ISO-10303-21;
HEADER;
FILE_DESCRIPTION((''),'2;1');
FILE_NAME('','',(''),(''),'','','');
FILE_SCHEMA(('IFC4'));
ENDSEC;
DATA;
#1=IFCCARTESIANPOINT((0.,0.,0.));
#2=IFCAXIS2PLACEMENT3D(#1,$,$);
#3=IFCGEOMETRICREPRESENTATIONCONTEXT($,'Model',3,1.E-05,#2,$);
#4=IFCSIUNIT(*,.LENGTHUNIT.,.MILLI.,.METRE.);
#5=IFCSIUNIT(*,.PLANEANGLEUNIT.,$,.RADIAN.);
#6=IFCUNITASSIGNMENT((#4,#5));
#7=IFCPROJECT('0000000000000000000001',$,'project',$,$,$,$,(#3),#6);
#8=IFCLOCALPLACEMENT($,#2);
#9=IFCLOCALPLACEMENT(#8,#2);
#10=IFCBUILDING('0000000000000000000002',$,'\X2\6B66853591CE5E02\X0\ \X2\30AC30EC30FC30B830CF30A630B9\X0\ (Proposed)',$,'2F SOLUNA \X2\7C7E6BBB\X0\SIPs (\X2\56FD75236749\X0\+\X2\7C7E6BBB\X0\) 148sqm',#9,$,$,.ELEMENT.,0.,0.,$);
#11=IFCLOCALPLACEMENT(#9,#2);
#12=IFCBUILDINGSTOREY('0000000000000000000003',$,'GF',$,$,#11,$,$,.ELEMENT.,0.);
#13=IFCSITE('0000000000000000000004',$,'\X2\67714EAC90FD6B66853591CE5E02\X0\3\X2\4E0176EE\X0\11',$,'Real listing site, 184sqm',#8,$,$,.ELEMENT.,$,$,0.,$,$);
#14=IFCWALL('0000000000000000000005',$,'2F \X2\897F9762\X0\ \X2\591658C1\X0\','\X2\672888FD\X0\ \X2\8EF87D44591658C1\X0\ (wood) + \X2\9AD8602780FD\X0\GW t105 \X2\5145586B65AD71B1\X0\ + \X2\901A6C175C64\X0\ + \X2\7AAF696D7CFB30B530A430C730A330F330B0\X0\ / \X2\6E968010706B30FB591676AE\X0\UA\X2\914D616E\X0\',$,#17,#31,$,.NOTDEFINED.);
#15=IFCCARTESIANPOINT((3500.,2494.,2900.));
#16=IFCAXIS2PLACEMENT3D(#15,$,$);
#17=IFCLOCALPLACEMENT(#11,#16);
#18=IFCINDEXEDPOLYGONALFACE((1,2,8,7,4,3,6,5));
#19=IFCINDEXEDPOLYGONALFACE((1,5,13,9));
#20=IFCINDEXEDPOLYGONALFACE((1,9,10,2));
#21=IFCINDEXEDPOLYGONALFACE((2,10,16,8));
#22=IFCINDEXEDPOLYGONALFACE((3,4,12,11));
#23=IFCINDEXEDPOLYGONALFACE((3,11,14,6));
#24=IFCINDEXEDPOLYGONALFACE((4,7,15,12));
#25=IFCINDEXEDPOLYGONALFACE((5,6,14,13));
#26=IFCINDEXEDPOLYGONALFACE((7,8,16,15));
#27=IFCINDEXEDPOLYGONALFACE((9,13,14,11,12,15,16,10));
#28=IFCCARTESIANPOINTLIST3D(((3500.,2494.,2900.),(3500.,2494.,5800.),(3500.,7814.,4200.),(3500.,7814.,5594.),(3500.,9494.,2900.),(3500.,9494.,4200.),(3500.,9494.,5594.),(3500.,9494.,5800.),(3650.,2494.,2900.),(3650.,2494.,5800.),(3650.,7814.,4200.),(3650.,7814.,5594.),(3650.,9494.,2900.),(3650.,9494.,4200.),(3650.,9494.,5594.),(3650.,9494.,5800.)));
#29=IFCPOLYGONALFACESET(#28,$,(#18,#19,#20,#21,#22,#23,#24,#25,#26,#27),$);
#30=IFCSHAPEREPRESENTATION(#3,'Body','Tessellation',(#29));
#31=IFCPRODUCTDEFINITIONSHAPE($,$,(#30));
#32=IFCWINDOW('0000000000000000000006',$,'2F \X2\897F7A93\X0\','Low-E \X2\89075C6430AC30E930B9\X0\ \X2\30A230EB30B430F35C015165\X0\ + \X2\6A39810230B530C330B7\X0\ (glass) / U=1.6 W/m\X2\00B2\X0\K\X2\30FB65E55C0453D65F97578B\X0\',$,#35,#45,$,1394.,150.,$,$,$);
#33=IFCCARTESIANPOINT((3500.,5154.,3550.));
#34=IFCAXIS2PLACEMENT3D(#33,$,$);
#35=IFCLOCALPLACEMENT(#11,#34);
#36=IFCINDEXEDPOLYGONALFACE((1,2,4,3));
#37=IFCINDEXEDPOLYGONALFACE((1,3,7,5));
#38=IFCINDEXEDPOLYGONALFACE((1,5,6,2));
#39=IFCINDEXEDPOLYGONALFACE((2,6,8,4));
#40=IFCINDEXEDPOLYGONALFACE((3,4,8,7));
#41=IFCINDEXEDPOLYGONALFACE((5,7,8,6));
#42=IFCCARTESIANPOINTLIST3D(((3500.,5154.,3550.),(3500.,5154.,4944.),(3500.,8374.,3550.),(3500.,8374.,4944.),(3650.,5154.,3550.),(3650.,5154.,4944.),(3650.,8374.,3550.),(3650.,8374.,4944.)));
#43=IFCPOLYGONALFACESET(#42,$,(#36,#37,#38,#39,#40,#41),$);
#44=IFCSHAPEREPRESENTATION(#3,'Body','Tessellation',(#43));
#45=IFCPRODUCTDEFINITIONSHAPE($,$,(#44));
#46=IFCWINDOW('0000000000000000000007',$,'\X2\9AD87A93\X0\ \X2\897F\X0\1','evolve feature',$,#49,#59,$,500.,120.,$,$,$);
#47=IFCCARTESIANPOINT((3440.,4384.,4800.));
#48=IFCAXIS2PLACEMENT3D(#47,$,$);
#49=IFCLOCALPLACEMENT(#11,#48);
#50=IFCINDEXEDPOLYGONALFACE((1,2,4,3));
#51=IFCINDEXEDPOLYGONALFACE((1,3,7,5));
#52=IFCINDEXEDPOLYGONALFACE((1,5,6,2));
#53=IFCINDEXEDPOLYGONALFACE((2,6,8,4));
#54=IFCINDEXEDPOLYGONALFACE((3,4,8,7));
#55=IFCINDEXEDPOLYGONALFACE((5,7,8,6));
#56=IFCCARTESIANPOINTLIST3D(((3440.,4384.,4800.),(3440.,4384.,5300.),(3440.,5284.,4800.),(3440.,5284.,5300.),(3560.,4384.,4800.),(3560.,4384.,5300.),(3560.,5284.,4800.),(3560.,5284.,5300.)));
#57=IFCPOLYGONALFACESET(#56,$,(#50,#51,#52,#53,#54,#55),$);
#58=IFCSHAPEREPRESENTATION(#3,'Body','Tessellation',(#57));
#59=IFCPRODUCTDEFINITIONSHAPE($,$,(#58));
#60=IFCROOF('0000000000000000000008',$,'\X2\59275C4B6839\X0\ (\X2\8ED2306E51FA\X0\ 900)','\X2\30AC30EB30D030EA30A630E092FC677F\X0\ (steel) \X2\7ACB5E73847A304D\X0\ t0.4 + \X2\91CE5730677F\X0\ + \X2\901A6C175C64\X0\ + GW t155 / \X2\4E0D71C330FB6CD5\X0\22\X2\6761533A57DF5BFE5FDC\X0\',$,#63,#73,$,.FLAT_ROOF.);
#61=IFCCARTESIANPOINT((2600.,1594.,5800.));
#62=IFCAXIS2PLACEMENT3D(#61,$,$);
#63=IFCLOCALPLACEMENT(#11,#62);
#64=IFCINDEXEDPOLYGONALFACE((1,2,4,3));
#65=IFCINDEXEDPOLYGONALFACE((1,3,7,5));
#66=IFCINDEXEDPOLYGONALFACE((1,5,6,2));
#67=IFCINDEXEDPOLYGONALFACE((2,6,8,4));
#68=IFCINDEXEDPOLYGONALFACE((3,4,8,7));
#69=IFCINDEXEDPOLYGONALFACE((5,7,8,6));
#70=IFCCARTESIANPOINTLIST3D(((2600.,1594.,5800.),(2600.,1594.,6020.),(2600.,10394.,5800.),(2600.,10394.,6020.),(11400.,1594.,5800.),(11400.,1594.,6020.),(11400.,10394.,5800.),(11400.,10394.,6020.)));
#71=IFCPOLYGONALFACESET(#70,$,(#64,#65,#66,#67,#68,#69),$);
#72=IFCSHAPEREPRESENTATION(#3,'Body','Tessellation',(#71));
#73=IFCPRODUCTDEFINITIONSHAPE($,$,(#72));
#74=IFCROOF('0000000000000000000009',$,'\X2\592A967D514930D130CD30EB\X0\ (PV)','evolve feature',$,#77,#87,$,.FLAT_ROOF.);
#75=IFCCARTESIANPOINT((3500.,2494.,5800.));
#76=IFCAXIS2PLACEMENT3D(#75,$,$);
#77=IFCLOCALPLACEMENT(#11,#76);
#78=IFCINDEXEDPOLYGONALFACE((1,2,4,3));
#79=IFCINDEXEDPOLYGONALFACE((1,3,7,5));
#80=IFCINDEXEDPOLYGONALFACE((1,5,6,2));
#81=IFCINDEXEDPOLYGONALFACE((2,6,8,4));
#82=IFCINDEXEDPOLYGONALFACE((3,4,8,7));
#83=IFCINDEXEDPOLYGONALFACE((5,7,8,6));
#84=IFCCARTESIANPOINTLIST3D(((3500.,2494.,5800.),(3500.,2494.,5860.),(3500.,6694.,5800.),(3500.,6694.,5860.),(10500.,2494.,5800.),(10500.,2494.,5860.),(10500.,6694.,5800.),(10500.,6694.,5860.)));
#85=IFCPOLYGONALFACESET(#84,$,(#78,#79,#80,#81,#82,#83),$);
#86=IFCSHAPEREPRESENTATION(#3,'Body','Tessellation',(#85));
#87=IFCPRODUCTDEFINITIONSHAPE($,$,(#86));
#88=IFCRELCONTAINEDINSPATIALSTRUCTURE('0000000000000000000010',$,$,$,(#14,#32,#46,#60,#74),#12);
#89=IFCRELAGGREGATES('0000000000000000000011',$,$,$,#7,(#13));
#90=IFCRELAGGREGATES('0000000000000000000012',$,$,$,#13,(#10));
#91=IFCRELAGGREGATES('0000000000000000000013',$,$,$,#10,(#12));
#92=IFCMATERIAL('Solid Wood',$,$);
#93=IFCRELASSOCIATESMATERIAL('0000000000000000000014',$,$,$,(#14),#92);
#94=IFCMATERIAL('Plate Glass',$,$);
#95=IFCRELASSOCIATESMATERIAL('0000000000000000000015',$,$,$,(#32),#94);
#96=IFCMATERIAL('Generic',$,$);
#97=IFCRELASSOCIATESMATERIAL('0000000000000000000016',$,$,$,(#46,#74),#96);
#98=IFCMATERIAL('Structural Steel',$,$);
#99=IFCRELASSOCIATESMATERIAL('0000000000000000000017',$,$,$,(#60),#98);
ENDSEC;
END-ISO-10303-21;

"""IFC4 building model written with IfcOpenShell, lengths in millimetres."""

from ifc_helpers import new_model, si_unit, frame, frame_2d, origin, place, context, project, spatial, rectangle, extrude, material, element, fill, save


model = new_model("IFC4")

# Units and contexts
model_context = context("Model", 3, precision=1e-05, world=origin())
ifc_project = project(units=[si_unit("LENGTHUNIT", "METRE", prefix="MILLI"), si_unit("PLANEANGLEUNIT", "RADIAN")], contexts=[model_context])

# Site, building, storey
site_placement = place(None, origin())
site = spatial("IfcSite", under=ifc_project, at=site_placement, Name="東京都武蔵野市3丁目11", ObjectType="Real listing site, 184sqm", CompositionType="ELEMENT", RefElevation=0.0)
building_placement = place(site_placement, origin())
building = spatial("IfcBuilding", under=site, at=building_placement, Name="武蔵野市 ガレージハウス (Proposed)", ObjectType="2F SOLUNA 籾殻SIPs (国産杉+籾殻) 148sqm", CompositionType="ELEMENT", ElevationOfRefHeight=0.0, ElevationOfTerrain=0.0)
storey_placement = place(building_placement, origin())
storey = spatial("IfcBuildingStorey", under=building, at=storey_placement, Name="GF", CompositionType="ELEMENT", Elevation=0.0)

# Shared definitions
ifc_material_1 = material(Name="Solid Wood")
ifc_material_2 = material(Name="Generic")

# Shared definitions
ifc_material_3 = material(Name="Plate Glass")

# Wall, openings, windows
wall_1_placement = place(storey_placement, frame((3500.0, 2494.0, 2900.0)))
wall_1 = element("IfcWall", 1, at=wall_1_placement, inside=storey, material=ifc_material_1, Name="2F 西面 外壁", Description="木製 軸組外壁 (wood) + 高性能GW t105 充填断熱 + 通気層 + 窯業系サイディング / 準耐火・外皮UA配慮", PredefinedType="NOTDEFINED", context=model_context, shape_type="SweptSolid", body=[
    extrude(rectangle(XDim=150.0, YDim=7000.0, at=frame_2d((75.0, 3500.0))), frame((3500.0, 2494.0, 2900.0)), (0.0, 0.0, 1.0), 2900.0),
])
opening_1_placement = place(storey_placement, frame((3500.0, 5154.0, 3550.0)))
opening_1 = element("IfcOpeningElement", 2, at=opening_1_placement, cuts=wall_1, PredefinedType="NOTDEFINED", context=model_context, shape_type="SweptSolid", body=[
    extrude(rectangle(XDim=150.0, YDim=3220.0, at=frame_2d((75.0, 1610.0))), frame((3500.0, 5154.0, 3550.0)), (0.0, 0.0, 1.0), 1394.0),
])
opening_2_placement = place(storey_placement, frame((3440.0, 4384.0, 4800.0)))
opening_2 = element("IfcOpeningElement", 3, at=opening_2_placement, cuts=wall_1, PredefinedType="NOTDEFINED", context=model_context, shape_type="SweptSolid", body=[
    extrude(rectangle(XDim=120.0, YDim=900.0, at=frame_2d((60.0, 450.0))), frame((3440.0, 4384.0, 4800.0)), (0.0, 0.0, 1.0), 500.0),
])
window_1_placement = place(storey_placement, frame((3500.0, 5154.0, 3550.0)))
window_1 = element("IfcWindow", 4, at=window_1_placement, inside=storey, material=ifc_material_3, Name="2F 西窓", Description="Low-E 複層ガラス アルゴン封入 + 樹脂サッシ (glass) / U=1.6 W/m²K・日射取得型", OverallHeight=1394.0, OverallWidth=150.0, context=model_context, shape_type="SweptSolid", body=[
    extrude(rectangle(XDim=150.0, YDim=3220.0, at=frame_2d((75.0, 1610.0))), frame((3500.0, 5154.0, 3550.0)), (0.0, 0.0, 1.0), 1394.0),
])
fill(opening_1, window_1)
window_2_placement = place(storey_placement, frame((3440.0, 4384.0, 4800.0)))
window_2 = element("IfcWindow", 5, at=window_2_placement, inside=storey, material=ifc_material_2, Name="高窓 西1", Description="evolve feature", OverallHeight=500.0, OverallWidth=120.0, context=model_context, shape_type="SweptSolid", body=[
    extrude(rectangle(XDim=120.0, YDim=900.0, at=frame_2d((60.0, 450.0))), frame((3440.0, 4384.0, 4800.0)), (0.0, 0.0, 1.0), 500.0),
])
fill(opening_2, window_2)

# Roofs
ifc_material_4 = material(Name="Structural Steel")
roof_1_placement = place(storey_placement, frame((2600.0, 1594.0, 5800.0)))
element("IfcRoof", 6, at=roof_1_placement, inside=storey, material=ifc_material_4, Name="大屋根 (軒の出 900)", Description="ガルバリウム鋼板 (steel) 立平葺き t0.4 + 野地板 + 通気層 + GW t155 / 不燃・法22条区域対応", PredefinedType="FLAT_ROOF", context=model_context, shape_type="SweptSolid", body=[
    extrude(rectangle(XDim=8800.0, YDim=8800.0, at=frame_2d((4400.0, 4400.0))), frame((2600.0, 1594.0, 5800.0)), (0.0, 0.0, 1.0), 220.0),
])
roof_2_placement = place(storey_placement, frame((3500.0, 2494.0, 5800.0)))
element("IfcRoof", 7, at=roof_2_placement, inside=storey, material=ifc_material_2, Name="太陽光パネル (PV)", Description="evolve feature", PredefinedType="FLAT_ROOF", context=model_context, shape_type="SweptSolid", body=[
    extrude(rectangle(XDim=7000.0, YDim=4200.0, at=frame_2d((3500.0, 2100.0))), frame((3500.0, 2494.0, 5800.0)), (0.0, 0.0, 1.0), 60.0),
])

save(model, "model.ifc")
